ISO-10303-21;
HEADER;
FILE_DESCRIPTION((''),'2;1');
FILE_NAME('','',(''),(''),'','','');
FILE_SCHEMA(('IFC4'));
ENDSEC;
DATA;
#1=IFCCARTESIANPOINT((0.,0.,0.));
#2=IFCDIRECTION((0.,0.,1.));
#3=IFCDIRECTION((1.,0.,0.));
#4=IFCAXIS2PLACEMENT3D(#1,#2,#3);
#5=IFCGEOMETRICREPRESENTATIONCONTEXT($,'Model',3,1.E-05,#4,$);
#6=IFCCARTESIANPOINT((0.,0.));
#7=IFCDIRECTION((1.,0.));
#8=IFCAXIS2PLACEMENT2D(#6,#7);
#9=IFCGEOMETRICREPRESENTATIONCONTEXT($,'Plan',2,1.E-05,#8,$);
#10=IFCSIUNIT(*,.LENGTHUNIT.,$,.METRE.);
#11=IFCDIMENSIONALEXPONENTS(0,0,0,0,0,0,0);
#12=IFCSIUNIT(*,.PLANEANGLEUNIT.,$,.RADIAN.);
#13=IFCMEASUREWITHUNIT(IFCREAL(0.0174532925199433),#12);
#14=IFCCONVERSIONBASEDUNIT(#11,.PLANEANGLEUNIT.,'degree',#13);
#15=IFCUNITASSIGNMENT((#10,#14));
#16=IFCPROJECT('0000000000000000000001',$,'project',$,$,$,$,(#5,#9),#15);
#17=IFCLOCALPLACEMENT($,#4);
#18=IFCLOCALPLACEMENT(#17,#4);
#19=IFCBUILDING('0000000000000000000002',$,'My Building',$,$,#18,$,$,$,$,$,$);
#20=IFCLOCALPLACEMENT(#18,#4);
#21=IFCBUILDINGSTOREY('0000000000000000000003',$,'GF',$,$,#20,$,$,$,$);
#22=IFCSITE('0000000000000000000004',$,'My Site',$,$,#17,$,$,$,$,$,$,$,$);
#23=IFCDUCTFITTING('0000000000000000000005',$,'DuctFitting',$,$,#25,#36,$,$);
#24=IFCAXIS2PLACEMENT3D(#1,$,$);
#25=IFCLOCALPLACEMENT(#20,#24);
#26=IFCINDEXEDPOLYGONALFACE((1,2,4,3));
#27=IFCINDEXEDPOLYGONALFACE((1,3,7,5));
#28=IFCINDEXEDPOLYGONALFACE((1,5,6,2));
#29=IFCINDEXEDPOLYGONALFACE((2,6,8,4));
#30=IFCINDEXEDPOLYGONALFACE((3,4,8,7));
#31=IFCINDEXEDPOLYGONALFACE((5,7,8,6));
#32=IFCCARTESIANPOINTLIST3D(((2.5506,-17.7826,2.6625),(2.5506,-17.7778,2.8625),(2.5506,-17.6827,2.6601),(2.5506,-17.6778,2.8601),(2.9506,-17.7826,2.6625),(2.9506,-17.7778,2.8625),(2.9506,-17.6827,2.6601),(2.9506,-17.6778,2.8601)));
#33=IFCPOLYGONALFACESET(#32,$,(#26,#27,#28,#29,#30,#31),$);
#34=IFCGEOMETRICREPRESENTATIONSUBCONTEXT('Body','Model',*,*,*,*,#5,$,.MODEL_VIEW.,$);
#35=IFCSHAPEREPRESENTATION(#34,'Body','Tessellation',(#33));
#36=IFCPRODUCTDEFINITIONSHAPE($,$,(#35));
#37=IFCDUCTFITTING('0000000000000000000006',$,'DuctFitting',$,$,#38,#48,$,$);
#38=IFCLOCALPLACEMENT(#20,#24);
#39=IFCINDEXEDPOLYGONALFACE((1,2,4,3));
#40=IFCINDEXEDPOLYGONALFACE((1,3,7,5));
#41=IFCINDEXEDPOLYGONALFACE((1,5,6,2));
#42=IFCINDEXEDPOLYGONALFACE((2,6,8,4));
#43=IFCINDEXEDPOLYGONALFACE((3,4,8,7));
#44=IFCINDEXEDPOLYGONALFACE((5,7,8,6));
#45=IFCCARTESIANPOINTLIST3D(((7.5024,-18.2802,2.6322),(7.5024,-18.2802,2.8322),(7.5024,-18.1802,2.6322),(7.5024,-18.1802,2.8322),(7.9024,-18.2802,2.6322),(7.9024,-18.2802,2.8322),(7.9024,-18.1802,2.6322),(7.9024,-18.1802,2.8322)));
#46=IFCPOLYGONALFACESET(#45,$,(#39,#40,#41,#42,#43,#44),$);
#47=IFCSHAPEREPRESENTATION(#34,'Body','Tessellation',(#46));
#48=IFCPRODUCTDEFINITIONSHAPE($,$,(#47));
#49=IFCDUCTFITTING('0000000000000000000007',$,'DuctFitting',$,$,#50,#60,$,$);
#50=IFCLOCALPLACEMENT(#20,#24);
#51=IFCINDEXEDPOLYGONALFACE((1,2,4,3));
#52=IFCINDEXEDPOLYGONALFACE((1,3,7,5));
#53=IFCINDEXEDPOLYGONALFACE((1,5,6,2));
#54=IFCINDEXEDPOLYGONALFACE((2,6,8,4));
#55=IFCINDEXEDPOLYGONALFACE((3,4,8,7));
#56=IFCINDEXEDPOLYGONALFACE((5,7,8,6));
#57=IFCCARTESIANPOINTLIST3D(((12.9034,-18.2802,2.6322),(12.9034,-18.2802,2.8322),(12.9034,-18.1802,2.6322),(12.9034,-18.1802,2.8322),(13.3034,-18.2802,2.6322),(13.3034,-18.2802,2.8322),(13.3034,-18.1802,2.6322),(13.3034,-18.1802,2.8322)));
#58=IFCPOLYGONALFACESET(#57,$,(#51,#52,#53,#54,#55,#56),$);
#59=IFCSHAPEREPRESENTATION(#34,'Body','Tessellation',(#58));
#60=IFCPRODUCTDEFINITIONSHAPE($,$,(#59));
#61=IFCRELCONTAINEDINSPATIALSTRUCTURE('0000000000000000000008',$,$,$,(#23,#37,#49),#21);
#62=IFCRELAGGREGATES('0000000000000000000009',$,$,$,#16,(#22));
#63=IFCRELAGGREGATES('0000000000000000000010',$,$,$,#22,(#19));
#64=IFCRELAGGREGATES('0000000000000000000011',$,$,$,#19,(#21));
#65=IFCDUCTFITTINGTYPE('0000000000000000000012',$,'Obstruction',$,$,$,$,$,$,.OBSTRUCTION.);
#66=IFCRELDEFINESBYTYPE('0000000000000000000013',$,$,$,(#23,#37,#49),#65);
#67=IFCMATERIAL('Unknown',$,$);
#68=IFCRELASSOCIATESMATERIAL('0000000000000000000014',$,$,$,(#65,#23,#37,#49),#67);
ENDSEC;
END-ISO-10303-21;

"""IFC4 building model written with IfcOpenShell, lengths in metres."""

from ifc_helpers import new_model, entity, si_unit, converted_unit, frame, origin_with_axes, origin_2d_with_axis, place, context, subcontext, project, spatial, rectangle, extrude, material, material_profile, profile_set, profile_usage, type_object, element, save


model = new_model("IFC4")

# Units and contexts
model_context = context("Model", 3, precision=1e-05, world=origin_with_axes())
plan_context = context("Plan", 2, precision=1e-05, world=origin_2d_with_axis())
body_context_1 = subcontext(model_context, "Body", "Model", "MODEL_VIEW")
ifc_project = project(units=[si_unit("LENGTHUNIT", "METRE"), converted_unit("PLANEANGLEUNIT", "degree", entity("IfcReal", 0.0174532925199433), si_unit("PLANEANGLEUNIT", "RADIAN"), dimensions=[0, 0, 0, 0, 0, 0, 0])], contexts=[model_context, plan_context])

# Site, building, storey
site_placement = place(None, origin_with_axes())
site = spatial("IfcSite", under=ifc_project, at=site_placement, Name="My Site")
building_placement = place(site_placement, origin_with_axes())
building = spatial("IfcBuilding", under=site, at=building_placement, Name="My Building")
storey_placement = place(building_placement, origin_with_axes())
storey = spatial("IfcBuildingStorey", under=building, at=storey_placement, Name="GF")

# Shared definitions
ifc_material = material(Name="Unknown")

# Duct fittings
ifc_material_profile_1 = material_profile(ifc_material, rectangle(XDim=0.4, YDim=0.2))
ifc_profile_set_1 = profile_set([ifc_material_profile_1])
duct_fitting_type_1 = type_object("IfcDuctFittingType", Name="Obstruction", PredefinedType="OBSTRUCTION", material=ifc_profile_set_1)
ifc_profile_usage_1 = profile_usage(ifc_profile_set_1, cardinal=5)
duct_fitting_1_placement = place(storey_placement, frame((2.7506, -17.7802, 2.7625), z_axis=(0.0, 0.999706, -0.02423), x_axis=(-1.0, 0.0, 0.0)))
element("IfcDuctFitting", 1, at=duct_fitting_1_placement, inside=storey, type_object=duct_fitting_type_1, material=ifc_profile_usage_1, Name="DuctFitting", context=body_context_1, shape_type="SweptSolid", body=[
    extrude(rectangle(XDim=0.4, YDim=0.2), origin_with_axes(), (0.0, 0.0, 1.0), 0.1),
])
ifc_profile_usage_2 = profile_usage(ifc_profile_set_1, cardinal=5)
duct_fitting_2_placement = place(storey_placement, frame((7.7024, -18.1802, 2.7322), z_axis=(0.0, -1.0, 0.0), x_axis=(1.0, 0.0, 0.0)))
element("IfcDuctFitting", 2, at=duct_fitting_2_placement, inside=storey, type_object=duct_fitting_type_1, material=ifc_profile_usage_2, Name="DuctFitting", context=body_context_1, shape_type="SweptSolid", body=[
    extrude(rectangle(XDim=0.4, YDim=0.2), origin_with_axes(), (0.0, 0.0, 1.0), 0.1),
])
ifc_profile_usage_3 = profile_usage(ifc_profile_set_1, cardinal=5)
duct_fitting_3_placement = place(storey_placement, frame((13.1034, -18.1802, 2.7322), z_axis=(0.0, -1.0, 0.0), x_axis=(1.0, 0.0, 0.0)))
element("IfcDuctFitting", 3, at=duct_fitting_3_placement, inside=storey, type_object=duct_fitting_type_1, material=ifc_profile_usage_3, Name="DuctFitting", context=body_context_1, shape_type="SweptSolid", body=[
    extrude(rectangle(XDim=0.4, YDim=0.2), origin_with_axes(), (0.0, 0.0, 1.0), 0.1),
])

save(model, "model.ifc")
